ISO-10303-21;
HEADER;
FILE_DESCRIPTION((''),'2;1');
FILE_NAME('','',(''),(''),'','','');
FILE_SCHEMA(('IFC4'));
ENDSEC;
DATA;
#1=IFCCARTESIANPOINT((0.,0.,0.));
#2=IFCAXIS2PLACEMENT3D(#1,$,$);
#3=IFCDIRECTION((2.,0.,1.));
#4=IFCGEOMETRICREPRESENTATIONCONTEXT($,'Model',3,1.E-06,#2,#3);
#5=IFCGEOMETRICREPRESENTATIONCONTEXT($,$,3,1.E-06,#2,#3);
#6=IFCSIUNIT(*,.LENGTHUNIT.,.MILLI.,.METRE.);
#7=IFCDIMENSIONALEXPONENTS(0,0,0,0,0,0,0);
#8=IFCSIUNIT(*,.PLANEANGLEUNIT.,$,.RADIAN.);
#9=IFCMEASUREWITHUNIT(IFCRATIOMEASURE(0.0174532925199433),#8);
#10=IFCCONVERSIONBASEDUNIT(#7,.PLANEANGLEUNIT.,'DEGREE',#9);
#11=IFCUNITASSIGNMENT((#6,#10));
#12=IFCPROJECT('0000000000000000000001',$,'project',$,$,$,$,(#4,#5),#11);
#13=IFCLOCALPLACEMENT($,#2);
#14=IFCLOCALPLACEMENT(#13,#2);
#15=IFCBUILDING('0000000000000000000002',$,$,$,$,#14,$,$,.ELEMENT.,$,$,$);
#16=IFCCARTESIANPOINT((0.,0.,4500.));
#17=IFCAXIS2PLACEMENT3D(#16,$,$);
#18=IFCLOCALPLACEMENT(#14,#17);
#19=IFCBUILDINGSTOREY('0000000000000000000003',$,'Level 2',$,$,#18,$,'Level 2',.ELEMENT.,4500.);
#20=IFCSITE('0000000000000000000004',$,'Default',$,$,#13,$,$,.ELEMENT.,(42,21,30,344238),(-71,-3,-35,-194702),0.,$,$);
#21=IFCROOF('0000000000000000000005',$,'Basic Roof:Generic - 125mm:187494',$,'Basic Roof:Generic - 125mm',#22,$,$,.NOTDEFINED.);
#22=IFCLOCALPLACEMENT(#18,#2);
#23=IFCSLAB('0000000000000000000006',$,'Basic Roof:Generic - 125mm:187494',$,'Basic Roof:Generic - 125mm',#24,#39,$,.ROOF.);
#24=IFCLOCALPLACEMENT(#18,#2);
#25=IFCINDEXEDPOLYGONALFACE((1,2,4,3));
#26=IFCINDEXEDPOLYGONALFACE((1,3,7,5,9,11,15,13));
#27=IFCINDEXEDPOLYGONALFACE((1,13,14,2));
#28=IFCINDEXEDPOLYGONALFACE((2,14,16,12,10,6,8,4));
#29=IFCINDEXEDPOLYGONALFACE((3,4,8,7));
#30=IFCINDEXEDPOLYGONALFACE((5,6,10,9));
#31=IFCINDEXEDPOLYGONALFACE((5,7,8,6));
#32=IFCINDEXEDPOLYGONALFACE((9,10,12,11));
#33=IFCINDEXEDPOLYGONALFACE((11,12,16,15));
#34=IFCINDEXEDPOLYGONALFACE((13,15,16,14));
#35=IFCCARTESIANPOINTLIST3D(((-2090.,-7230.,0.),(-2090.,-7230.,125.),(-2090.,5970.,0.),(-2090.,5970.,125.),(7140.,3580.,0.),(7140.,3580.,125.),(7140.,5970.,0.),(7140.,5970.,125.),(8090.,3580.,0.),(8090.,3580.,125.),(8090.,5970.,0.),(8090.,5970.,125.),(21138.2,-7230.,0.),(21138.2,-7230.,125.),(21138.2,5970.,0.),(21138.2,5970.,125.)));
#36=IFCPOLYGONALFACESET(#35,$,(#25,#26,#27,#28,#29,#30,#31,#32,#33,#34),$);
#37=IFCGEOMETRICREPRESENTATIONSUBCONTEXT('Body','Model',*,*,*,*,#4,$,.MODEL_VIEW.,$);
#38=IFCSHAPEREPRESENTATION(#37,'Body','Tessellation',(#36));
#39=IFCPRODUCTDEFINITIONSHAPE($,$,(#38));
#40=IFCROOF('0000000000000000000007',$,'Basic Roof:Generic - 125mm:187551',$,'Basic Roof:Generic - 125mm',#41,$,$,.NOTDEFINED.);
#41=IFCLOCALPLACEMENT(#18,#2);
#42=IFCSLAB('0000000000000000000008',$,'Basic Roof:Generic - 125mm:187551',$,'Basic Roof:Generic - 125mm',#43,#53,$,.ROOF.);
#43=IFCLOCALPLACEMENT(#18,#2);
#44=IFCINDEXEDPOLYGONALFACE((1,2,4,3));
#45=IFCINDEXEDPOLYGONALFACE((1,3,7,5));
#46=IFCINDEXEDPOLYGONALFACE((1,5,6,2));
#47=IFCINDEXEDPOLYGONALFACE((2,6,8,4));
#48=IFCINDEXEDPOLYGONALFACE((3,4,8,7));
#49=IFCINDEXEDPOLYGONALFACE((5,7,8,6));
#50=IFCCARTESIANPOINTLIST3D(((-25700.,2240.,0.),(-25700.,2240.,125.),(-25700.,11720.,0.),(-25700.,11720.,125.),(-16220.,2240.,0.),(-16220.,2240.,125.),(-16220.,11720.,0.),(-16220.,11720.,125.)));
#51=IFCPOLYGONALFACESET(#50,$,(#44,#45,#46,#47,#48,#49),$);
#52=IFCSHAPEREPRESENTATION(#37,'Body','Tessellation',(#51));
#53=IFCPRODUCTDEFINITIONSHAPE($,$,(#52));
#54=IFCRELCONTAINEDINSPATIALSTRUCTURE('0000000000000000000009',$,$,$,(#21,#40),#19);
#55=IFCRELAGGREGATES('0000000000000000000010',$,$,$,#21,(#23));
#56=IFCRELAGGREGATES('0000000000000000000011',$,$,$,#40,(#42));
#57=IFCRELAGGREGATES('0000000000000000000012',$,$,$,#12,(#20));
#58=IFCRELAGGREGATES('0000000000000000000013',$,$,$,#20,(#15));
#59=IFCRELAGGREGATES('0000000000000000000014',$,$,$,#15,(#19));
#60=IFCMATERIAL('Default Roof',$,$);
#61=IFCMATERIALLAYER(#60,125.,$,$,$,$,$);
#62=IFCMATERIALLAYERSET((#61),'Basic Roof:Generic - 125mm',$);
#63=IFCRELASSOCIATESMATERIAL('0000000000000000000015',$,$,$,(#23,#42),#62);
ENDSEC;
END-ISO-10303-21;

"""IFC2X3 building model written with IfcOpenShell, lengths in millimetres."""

from ifc_helpers import new_model, entity, si_unit, converted_unit, direction, frame, frame_2d, origin, origin_2d_with_axis, place, context, subcontext, project, spatial, rectangle, extrude, material, layer, layer_set, element, aggregate, save


model = new_model("IFC2X3")

# Units and contexts
model_context = context("Model", 3, precision=1e-06, world=origin(), true_north=direction((2.0, 0.0, 1.0)))
context_of_model = context(None, 3, precision=1e-06, world=origin(), true_north=direction((2.0, 0.0, 1.0)))
body_context = subcontext(model_context, "Body", "Model", "MODEL_VIEW")
ifc_project = project(units=[si_unit("LENGTHUNIT", "METRE", prefix="MILLI"), converted_unit("PLANEANGLEUNIT", "DEGREE", entity("IfcRatioMeasure", 0.0174532925199433), si_unit("PLANEANGLEUNIT", "RADIAN"), dimensions=[0, 0, 0, 0, 0, 0, 0])], contexts=[model_context, context_of_model])

# Site, building, storey
site_placement = place(None, origin())
site = spatial("IfcSite", under=ifc_project, at=site_placement, Name="Default", CompositionType="ELEMENT", RefLatitude=(42, 21, 30, 344238), RefLongitude=(-71, -3, -35, -194702), RefElevation=0.0)
building_placement = place(site_placement, origin())
building = spatial("IfcBuilding", under=site, at=building_placement, CompositionType="ELEMENT")
storey_placement = place(building_placement, frame((0.0, 0.0, 4500.0)))
storey = spatial("IfcBuildingStorey", under=building, at=storey_placement, Name="Level 2", LongName="Level 2", CompositionType="ELEMENT", Elevation=4500.0)

# Roof, slab, opening
roof_1_placement = place(storey_placement, origin())
roof_1 = element("IfcRoof", 1, at=roof_1_placement, inside=storey, Name="Basic Roof:Generic - 125mm:187494", ObjectType="Basic Roof:Generic - 125mm", ShapeType="NOTDEFINED")
ifc_material = material(Name="Default Roof")
ifc_layer = layer(ifc_material, 125.0)
ifc_layer_set = layer_set([ifc_layer], Name="Basic Roof:Generic - 125mm")
slab_1_placement = place(roof_1_placement, frame((-2090.0, -7230.0, 0.0)))
slab_1 = element("IfcSlab", 2, at=slab_1_placement, material=ifc_layer_set, Name="Basic Roof:Generic - 125mm:187494", ObjectType="Basic Roof:Generic - 125mm", PredefinedType="ROOF", context=body_context, shape_type="SweptSolid", body=[
    extrude(rectangle(XDim=23228.2, YDim=13200.0, at=frame_2d((0.0, 0.0), x_axis=(-1.0, 0.0))), frame((11614.1, 6600.0, 0.0)), (0.0, 0.0, 1.0), 125.0),
])
opening_placement = place(roof_1_placement, frame((7615.0, 6680.0, 0.0)))
element("IfcOpeningElement", 3, at=opening_placement, cuts=slab_1, ObjectType="Opening", context=body_context, shape_type="SweptSolid", body=[
    extrude(rectangle(XDim=950.0, YDim=6200.0, at=origin_2d_with_axis()), origin(), (0.0, 0.0, 1.0), 125.0),
])
aggregate(roof_1, [slab_1])

# Roof, slab
roof_2_placement = place(storey_placement, origin())
roof_2 = element("IfcRoof", 4, at=roof_2_placement, inside=storey, Name="Basic Roof:Generic - 125mm:187551", ObjectType="Basic Roof:Generic - 125mm", ShapeType="NOTDEFINED")
slab_2_placement = place(roof_2_placement, frame((-25700.0, 2240.0, 0.0)))
slab_2 = element("IfcSlab", 5, at=slab_2_placement, material=ifc_layer_set, Name="Basic Roof:Generic - 125mm:187551", ObjectType="Basic Roof:Generic - 125mm", PredefinedType="ROOF", context=body_context, shape_type="SweptSolid", body=[
    extrude(rectangle(XDim=9480.0, YDim=9480.0, at=origin_2d_with_axis()), frame((4740.0, 4740.0, 0.0)), (0.0, 0.0, 1.0), 125.0),
])
aggregate(roof_2, [slab_2])

save(model, "model.ifc")
